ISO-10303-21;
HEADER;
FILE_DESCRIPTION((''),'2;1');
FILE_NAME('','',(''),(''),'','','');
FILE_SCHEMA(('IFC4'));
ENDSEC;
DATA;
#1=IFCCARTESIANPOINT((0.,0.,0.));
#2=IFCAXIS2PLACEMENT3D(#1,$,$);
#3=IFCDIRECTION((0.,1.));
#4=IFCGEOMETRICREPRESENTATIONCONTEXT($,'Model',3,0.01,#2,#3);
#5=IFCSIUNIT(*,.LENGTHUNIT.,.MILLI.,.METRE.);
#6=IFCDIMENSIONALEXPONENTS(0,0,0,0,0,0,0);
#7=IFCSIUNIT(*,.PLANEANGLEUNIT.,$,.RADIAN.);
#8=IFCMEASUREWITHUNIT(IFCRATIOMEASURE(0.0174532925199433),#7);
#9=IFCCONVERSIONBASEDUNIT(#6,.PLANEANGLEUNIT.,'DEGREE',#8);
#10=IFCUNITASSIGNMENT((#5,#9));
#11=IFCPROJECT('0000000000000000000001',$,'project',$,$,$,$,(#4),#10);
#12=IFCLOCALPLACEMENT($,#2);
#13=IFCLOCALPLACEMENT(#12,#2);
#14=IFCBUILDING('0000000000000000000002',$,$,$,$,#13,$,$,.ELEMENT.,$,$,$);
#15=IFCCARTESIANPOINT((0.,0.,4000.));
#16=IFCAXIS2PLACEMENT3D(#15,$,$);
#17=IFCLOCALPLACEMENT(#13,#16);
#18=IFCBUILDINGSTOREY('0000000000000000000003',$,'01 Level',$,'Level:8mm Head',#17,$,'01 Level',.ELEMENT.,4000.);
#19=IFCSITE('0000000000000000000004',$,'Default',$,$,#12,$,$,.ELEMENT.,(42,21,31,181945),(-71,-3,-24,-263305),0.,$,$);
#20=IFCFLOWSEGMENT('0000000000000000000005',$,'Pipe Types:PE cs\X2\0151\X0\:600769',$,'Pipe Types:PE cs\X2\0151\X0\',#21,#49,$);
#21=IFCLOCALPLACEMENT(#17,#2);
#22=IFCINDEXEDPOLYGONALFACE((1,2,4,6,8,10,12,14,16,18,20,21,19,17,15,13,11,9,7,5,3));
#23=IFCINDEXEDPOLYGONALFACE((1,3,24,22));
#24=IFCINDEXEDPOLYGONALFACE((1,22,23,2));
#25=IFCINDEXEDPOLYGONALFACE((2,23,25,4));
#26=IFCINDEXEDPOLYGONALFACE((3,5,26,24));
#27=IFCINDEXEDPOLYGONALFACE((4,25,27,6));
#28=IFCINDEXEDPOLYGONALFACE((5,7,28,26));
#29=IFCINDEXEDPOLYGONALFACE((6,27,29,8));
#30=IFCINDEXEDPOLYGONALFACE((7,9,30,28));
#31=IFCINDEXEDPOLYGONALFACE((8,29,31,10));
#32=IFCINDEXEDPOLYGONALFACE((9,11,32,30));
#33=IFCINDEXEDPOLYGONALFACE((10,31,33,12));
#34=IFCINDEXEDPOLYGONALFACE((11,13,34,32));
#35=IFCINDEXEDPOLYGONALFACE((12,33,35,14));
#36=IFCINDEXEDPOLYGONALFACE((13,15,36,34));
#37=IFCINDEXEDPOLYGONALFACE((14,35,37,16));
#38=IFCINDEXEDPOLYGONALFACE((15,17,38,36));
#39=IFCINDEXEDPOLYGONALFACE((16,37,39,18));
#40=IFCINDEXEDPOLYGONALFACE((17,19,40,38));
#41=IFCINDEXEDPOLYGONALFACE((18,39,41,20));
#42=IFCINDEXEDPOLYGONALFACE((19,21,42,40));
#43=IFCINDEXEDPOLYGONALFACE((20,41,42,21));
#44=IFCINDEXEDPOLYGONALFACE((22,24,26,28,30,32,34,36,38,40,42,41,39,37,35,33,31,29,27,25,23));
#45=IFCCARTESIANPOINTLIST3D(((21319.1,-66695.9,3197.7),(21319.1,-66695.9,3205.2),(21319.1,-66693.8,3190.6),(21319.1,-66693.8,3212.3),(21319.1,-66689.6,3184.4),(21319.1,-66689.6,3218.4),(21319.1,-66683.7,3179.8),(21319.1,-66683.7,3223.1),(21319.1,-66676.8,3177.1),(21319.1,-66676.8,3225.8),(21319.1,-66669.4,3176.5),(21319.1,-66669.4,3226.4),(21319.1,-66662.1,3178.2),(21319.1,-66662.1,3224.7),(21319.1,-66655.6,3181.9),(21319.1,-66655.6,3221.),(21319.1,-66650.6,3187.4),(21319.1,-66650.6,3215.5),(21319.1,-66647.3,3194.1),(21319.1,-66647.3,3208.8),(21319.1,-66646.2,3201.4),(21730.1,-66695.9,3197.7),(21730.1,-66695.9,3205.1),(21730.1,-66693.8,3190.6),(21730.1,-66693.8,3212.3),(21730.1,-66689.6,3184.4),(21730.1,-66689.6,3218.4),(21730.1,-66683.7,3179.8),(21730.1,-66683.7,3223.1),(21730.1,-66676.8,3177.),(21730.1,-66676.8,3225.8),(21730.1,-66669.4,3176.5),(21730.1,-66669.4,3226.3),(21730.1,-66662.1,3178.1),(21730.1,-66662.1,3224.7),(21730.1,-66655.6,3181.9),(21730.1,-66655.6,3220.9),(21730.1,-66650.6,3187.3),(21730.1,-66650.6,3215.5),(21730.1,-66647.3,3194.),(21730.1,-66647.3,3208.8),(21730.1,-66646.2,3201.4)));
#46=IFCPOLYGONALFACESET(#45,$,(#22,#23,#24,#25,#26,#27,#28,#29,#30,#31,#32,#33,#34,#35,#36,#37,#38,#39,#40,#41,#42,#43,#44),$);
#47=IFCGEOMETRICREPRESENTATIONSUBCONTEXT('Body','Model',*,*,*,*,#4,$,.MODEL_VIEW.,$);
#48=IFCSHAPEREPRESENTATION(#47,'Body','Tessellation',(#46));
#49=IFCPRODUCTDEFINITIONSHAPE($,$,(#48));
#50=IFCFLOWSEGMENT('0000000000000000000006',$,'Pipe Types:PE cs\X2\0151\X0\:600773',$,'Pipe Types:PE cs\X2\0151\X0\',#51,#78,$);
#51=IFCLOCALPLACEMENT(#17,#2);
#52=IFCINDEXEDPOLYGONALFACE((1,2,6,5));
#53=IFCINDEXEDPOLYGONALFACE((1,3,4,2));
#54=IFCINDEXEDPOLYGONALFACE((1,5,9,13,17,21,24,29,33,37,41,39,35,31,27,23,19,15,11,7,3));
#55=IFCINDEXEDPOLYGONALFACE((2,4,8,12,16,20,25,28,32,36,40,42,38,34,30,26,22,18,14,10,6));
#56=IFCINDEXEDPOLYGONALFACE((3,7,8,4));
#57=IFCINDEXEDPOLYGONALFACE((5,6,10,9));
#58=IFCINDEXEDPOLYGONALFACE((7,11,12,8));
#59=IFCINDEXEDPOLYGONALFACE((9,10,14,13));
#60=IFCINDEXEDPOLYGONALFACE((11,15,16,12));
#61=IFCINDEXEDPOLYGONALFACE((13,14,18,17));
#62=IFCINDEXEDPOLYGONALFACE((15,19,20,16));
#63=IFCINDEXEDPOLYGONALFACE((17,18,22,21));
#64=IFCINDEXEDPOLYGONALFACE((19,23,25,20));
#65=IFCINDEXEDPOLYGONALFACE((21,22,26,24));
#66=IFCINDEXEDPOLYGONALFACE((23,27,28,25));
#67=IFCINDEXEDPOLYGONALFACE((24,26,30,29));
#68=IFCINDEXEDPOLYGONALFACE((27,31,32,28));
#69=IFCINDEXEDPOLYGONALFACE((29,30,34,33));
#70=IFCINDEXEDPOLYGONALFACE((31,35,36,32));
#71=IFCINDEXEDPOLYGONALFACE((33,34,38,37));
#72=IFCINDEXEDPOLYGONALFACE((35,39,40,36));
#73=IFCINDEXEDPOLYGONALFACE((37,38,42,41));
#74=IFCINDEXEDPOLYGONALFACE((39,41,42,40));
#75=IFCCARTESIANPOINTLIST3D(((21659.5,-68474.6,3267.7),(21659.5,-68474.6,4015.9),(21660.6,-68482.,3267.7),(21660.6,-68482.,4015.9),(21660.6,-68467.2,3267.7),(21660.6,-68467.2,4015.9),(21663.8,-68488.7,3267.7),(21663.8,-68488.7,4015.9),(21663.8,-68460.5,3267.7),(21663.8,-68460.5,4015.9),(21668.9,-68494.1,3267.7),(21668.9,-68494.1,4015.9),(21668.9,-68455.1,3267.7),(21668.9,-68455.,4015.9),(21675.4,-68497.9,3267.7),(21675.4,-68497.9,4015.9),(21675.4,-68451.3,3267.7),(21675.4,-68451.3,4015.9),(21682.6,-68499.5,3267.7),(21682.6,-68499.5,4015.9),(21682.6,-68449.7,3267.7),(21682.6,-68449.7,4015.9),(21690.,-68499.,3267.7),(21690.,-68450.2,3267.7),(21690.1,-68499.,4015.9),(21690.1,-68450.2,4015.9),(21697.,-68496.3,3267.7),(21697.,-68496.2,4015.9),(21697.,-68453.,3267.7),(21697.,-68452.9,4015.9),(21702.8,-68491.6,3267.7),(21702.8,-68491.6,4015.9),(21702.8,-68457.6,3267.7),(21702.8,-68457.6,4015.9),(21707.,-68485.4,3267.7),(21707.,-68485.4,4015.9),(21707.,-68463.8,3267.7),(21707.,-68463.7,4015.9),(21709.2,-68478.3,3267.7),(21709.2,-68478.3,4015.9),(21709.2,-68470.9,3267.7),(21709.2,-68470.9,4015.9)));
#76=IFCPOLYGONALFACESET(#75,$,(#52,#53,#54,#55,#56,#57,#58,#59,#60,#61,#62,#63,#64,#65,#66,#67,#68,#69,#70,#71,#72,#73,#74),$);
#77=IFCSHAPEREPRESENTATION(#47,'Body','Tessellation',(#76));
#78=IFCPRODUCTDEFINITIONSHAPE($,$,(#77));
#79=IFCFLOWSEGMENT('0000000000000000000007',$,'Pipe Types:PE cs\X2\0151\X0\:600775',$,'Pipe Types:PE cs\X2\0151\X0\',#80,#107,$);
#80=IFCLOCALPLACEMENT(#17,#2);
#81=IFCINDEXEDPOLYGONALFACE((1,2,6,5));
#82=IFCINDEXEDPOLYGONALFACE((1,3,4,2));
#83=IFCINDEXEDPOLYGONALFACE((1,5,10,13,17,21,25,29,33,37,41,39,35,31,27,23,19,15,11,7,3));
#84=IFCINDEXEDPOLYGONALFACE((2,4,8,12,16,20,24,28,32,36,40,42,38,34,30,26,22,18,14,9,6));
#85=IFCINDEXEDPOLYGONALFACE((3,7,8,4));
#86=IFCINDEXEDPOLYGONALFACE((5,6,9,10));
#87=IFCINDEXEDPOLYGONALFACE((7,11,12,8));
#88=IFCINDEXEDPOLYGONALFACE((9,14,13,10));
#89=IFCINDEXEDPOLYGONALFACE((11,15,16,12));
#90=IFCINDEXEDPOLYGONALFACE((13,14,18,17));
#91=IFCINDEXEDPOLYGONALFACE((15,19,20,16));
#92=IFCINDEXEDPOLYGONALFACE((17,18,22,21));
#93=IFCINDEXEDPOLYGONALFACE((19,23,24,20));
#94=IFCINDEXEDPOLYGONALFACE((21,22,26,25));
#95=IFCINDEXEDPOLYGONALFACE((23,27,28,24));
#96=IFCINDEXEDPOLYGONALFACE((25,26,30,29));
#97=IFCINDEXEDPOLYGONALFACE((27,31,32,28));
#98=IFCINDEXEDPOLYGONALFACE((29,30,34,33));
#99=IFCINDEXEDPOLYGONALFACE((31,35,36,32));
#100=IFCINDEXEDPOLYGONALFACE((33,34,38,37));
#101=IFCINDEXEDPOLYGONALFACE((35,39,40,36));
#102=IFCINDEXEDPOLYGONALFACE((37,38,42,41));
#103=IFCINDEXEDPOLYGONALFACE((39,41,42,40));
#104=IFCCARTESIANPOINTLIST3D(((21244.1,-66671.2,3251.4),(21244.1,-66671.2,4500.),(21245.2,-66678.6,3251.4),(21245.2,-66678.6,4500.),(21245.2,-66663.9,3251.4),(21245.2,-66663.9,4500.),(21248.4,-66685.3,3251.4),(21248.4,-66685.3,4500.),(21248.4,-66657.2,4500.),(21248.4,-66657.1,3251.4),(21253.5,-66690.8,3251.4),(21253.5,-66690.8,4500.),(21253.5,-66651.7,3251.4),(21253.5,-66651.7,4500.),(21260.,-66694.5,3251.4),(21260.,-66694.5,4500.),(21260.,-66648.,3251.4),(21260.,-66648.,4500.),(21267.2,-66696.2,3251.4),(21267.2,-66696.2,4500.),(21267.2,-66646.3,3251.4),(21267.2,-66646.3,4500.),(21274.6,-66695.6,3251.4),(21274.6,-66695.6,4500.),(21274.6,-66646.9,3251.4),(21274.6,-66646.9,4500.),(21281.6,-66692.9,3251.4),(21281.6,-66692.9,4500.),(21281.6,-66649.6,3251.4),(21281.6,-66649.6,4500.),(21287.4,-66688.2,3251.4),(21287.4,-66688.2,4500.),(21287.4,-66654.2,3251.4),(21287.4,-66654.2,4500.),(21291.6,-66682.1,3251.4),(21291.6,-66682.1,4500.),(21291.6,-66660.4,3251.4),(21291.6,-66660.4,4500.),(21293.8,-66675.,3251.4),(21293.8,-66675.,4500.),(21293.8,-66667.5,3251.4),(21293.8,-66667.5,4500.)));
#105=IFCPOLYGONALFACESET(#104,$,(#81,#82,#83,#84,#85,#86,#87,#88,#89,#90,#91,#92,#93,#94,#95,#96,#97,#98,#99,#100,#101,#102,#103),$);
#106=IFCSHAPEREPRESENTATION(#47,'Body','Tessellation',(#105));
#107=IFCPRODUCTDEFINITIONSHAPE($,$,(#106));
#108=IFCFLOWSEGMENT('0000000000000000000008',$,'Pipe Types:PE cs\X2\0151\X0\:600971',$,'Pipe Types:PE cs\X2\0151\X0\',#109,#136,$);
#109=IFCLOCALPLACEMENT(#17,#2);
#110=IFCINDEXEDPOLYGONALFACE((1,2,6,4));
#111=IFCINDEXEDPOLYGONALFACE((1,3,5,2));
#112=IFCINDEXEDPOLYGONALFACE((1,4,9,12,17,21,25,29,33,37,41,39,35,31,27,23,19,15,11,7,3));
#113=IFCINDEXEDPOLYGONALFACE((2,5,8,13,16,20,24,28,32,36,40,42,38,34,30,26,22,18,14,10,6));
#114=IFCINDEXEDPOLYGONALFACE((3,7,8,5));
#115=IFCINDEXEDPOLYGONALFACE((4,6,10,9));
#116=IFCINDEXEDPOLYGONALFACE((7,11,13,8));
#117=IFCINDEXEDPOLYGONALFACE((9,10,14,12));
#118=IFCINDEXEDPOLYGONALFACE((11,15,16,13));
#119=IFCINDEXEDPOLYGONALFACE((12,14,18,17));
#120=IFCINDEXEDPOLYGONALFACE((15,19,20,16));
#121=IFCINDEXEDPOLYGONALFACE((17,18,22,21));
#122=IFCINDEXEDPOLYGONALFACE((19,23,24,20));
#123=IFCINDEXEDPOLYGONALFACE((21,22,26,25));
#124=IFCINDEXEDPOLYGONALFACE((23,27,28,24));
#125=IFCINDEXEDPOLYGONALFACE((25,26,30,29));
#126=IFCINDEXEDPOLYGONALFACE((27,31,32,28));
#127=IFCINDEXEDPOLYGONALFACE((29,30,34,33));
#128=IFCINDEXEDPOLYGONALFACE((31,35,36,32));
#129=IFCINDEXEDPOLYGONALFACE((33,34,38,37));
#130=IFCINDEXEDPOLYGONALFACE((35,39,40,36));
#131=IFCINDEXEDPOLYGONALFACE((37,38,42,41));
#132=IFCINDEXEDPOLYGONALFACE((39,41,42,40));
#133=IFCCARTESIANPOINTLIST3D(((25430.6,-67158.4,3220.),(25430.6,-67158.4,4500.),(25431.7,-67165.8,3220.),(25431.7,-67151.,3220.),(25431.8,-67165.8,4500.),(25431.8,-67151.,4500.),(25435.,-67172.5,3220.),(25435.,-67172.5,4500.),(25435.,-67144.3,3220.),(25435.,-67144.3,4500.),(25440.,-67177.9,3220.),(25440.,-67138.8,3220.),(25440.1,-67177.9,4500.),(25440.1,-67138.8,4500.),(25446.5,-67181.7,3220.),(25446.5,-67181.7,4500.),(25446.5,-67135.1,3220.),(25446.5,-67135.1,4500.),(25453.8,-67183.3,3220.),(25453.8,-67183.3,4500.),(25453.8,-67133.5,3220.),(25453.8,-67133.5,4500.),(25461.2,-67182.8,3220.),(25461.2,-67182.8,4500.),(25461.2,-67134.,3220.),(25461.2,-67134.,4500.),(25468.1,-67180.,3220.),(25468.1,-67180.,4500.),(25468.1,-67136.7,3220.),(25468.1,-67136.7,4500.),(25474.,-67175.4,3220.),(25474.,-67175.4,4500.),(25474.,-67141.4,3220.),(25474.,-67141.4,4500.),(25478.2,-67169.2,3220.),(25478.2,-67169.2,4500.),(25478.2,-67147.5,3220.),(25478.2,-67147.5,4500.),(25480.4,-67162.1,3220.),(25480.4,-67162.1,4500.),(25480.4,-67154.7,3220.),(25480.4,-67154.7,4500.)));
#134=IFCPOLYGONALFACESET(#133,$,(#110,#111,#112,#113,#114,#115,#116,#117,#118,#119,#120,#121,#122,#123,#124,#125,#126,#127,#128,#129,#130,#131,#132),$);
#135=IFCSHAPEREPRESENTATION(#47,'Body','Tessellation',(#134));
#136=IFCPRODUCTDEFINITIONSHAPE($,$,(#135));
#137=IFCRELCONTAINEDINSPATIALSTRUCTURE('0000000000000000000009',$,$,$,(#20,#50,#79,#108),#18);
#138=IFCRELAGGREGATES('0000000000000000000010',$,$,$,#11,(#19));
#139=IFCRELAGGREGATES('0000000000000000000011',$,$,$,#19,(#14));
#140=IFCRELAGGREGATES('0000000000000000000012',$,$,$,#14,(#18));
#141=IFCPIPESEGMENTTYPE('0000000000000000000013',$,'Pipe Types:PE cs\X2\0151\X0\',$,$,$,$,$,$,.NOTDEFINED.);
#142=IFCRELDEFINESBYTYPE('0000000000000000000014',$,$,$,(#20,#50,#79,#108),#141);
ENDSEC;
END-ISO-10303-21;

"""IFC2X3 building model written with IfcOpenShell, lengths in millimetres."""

from ifc_helpers import new_model, entity, si_unit, converted_unit, direction, frame, frame_2d, origin, place, context, subcontext, project, spatial, circle, extrude, type_object, element, save


model = new_model("IFC2X3")

# Units and contexts
model_context = context("Model", 3, precision=0.01, world=origin(), true_north=direction((0.0, 1.0)))
body_context = subcontext(model_context, "Body", "Model", "MODEL_VIEW")
ifc_project = project(units=[si_unit("LENGTHUNIT", "METRE", prefix="MILLI"), converted_unit("PLANEANGLEUNIT", "DEGREE", entity("IfcRatioMeasure", 0.0174532925199433), si_unit("PLANEANGLEUNIT", "RADIAN"), dimensions=[0, 0, 0, 0, 0, 0, 0])], contexts=[model_context])

# Site, building, storey
site_placement = place(None, origin())
site = spatial("IfcSite", under=ifc_project, at=site_placement, Name="Default", CompositionType="ELEMENT", RefLatitude=(42, 21, 31, 181945), RefLongitude=(-71, -3, -24, -263305), RefElevation=0.0)
building_placement = place(site_placement, origin())
building = spatial("IfcBuilding", under=site, at=building_placement, CompositionType="ELEMENT")
storey_placement = place(building_placement, frame((0.0, 0.0, 4000.0)))
storey = spatial("IfcBuildingStorey", under=building, at=storey_placement, Name="01 Level", ObjectType="Level:8mm Head", LongName="01 Level", CompositionType="ELEMENT", Elevation=4000.0)

# Flow segments
pipe_segment_type = type_object("IfcPipeSegmentType", Name="Pipe Types:PE cső", PredefinedType="NOTDEFINED")
flow_segment_1_placement = place(storey_placement, frame((21319.1, -66697.8, 3174.8)))
element("IfcFlowSegment", 1, at=flow_segment_1_placement, inside=storey, type_object=pipe_segment_type, Name="Pipe Types:PE cső:600769", ObjectType="Pipe Types:PE cső", context=body_context, shape_type="SweptSolid", body=[
    extrude(circle(Radius=25.0, at=frame_2d((0.0, 0.0), x_axis=(1.0, 0.0))), frame((0.0, 26.6, 26.6), z_axis=(1.0, 0.0, -0.000085), x_axis=(0.0, 1.0, 0.0)), (0.0, 0.0, 1.0), 411.0),
])
flow_segment_2_placement = place(storey_placement, frame((21657.9, -68501.2, 3267.7)))
element("IfcFlowSegment", 2, at=flow_segment_2_placement, inside=storey, type_object=pipe_segment_type, Name="Pipe Types:PE cső:600773", ObjectType="Pipe Types:PE cső", context=body_context, shape_type="SweptSolid", body=[
    extrude(circle(Radius=25.0, at=frame_2d((0.0, 0.0), x_axis=(1.0, 0.0))), frame((26.6, 26.6, 0.0), z_axis=(0.000019, 0.000019, 1.0), x_axis=(-1.0, 0.0, 0.000019)), (0.0, 0.0, 1.0), 748.2),
])
flow_segment_3_placement = place(storey_placement, frame((21242.5, -66697.8, 3251.4)))
element("IfcFlowSegment", 3, at=flow_segment_3_placement, inside=storey, type_object=pipe_segment_type, Name="Pipe Types:PE cső:600775", ObjectType="Pipe Types:PE cső", context=body_context, shape_type="SweptSolid", body=[
    extrude(circle(Radius=25.0, at=frame_2d((0.0, 0.0), x_axis=(1.0, 0.0))), frame((26.6, 26.6, 0.0), z_axis=(0.0, -0.000009, 1.0), x_axis=(-1.0, 0.0, 0.0)), (0.0, 0.0, 1.0), 1248.6),
])
flow_segment_4_placement = place(storey_placement, frame((25429.0, -67185.0, 3220.0)))
element("IfcFlowSegment", 4, at=flow_segment_4_placement, inside=storey, type_object=pipe_segment_type, Name="Pipe Types:PE cső:600971", ObjectType="Pipe Types:PE cső", context=body_context, shape_type="SweptSolid", body=[
    extrude(circle(Radius=25.0, at=frame_2d((0.0, 0.0), x_axis=(1.0, 0.0))), frame((26.6, 26.6, 0.0), z_axis=(0.000007, 0.000001, 1.0), x_axis=(-1.0, 0.0, 0.000007)), (0.0, 0.0, 1.0), 1280.0),
])

save(model, "model.ifc")
